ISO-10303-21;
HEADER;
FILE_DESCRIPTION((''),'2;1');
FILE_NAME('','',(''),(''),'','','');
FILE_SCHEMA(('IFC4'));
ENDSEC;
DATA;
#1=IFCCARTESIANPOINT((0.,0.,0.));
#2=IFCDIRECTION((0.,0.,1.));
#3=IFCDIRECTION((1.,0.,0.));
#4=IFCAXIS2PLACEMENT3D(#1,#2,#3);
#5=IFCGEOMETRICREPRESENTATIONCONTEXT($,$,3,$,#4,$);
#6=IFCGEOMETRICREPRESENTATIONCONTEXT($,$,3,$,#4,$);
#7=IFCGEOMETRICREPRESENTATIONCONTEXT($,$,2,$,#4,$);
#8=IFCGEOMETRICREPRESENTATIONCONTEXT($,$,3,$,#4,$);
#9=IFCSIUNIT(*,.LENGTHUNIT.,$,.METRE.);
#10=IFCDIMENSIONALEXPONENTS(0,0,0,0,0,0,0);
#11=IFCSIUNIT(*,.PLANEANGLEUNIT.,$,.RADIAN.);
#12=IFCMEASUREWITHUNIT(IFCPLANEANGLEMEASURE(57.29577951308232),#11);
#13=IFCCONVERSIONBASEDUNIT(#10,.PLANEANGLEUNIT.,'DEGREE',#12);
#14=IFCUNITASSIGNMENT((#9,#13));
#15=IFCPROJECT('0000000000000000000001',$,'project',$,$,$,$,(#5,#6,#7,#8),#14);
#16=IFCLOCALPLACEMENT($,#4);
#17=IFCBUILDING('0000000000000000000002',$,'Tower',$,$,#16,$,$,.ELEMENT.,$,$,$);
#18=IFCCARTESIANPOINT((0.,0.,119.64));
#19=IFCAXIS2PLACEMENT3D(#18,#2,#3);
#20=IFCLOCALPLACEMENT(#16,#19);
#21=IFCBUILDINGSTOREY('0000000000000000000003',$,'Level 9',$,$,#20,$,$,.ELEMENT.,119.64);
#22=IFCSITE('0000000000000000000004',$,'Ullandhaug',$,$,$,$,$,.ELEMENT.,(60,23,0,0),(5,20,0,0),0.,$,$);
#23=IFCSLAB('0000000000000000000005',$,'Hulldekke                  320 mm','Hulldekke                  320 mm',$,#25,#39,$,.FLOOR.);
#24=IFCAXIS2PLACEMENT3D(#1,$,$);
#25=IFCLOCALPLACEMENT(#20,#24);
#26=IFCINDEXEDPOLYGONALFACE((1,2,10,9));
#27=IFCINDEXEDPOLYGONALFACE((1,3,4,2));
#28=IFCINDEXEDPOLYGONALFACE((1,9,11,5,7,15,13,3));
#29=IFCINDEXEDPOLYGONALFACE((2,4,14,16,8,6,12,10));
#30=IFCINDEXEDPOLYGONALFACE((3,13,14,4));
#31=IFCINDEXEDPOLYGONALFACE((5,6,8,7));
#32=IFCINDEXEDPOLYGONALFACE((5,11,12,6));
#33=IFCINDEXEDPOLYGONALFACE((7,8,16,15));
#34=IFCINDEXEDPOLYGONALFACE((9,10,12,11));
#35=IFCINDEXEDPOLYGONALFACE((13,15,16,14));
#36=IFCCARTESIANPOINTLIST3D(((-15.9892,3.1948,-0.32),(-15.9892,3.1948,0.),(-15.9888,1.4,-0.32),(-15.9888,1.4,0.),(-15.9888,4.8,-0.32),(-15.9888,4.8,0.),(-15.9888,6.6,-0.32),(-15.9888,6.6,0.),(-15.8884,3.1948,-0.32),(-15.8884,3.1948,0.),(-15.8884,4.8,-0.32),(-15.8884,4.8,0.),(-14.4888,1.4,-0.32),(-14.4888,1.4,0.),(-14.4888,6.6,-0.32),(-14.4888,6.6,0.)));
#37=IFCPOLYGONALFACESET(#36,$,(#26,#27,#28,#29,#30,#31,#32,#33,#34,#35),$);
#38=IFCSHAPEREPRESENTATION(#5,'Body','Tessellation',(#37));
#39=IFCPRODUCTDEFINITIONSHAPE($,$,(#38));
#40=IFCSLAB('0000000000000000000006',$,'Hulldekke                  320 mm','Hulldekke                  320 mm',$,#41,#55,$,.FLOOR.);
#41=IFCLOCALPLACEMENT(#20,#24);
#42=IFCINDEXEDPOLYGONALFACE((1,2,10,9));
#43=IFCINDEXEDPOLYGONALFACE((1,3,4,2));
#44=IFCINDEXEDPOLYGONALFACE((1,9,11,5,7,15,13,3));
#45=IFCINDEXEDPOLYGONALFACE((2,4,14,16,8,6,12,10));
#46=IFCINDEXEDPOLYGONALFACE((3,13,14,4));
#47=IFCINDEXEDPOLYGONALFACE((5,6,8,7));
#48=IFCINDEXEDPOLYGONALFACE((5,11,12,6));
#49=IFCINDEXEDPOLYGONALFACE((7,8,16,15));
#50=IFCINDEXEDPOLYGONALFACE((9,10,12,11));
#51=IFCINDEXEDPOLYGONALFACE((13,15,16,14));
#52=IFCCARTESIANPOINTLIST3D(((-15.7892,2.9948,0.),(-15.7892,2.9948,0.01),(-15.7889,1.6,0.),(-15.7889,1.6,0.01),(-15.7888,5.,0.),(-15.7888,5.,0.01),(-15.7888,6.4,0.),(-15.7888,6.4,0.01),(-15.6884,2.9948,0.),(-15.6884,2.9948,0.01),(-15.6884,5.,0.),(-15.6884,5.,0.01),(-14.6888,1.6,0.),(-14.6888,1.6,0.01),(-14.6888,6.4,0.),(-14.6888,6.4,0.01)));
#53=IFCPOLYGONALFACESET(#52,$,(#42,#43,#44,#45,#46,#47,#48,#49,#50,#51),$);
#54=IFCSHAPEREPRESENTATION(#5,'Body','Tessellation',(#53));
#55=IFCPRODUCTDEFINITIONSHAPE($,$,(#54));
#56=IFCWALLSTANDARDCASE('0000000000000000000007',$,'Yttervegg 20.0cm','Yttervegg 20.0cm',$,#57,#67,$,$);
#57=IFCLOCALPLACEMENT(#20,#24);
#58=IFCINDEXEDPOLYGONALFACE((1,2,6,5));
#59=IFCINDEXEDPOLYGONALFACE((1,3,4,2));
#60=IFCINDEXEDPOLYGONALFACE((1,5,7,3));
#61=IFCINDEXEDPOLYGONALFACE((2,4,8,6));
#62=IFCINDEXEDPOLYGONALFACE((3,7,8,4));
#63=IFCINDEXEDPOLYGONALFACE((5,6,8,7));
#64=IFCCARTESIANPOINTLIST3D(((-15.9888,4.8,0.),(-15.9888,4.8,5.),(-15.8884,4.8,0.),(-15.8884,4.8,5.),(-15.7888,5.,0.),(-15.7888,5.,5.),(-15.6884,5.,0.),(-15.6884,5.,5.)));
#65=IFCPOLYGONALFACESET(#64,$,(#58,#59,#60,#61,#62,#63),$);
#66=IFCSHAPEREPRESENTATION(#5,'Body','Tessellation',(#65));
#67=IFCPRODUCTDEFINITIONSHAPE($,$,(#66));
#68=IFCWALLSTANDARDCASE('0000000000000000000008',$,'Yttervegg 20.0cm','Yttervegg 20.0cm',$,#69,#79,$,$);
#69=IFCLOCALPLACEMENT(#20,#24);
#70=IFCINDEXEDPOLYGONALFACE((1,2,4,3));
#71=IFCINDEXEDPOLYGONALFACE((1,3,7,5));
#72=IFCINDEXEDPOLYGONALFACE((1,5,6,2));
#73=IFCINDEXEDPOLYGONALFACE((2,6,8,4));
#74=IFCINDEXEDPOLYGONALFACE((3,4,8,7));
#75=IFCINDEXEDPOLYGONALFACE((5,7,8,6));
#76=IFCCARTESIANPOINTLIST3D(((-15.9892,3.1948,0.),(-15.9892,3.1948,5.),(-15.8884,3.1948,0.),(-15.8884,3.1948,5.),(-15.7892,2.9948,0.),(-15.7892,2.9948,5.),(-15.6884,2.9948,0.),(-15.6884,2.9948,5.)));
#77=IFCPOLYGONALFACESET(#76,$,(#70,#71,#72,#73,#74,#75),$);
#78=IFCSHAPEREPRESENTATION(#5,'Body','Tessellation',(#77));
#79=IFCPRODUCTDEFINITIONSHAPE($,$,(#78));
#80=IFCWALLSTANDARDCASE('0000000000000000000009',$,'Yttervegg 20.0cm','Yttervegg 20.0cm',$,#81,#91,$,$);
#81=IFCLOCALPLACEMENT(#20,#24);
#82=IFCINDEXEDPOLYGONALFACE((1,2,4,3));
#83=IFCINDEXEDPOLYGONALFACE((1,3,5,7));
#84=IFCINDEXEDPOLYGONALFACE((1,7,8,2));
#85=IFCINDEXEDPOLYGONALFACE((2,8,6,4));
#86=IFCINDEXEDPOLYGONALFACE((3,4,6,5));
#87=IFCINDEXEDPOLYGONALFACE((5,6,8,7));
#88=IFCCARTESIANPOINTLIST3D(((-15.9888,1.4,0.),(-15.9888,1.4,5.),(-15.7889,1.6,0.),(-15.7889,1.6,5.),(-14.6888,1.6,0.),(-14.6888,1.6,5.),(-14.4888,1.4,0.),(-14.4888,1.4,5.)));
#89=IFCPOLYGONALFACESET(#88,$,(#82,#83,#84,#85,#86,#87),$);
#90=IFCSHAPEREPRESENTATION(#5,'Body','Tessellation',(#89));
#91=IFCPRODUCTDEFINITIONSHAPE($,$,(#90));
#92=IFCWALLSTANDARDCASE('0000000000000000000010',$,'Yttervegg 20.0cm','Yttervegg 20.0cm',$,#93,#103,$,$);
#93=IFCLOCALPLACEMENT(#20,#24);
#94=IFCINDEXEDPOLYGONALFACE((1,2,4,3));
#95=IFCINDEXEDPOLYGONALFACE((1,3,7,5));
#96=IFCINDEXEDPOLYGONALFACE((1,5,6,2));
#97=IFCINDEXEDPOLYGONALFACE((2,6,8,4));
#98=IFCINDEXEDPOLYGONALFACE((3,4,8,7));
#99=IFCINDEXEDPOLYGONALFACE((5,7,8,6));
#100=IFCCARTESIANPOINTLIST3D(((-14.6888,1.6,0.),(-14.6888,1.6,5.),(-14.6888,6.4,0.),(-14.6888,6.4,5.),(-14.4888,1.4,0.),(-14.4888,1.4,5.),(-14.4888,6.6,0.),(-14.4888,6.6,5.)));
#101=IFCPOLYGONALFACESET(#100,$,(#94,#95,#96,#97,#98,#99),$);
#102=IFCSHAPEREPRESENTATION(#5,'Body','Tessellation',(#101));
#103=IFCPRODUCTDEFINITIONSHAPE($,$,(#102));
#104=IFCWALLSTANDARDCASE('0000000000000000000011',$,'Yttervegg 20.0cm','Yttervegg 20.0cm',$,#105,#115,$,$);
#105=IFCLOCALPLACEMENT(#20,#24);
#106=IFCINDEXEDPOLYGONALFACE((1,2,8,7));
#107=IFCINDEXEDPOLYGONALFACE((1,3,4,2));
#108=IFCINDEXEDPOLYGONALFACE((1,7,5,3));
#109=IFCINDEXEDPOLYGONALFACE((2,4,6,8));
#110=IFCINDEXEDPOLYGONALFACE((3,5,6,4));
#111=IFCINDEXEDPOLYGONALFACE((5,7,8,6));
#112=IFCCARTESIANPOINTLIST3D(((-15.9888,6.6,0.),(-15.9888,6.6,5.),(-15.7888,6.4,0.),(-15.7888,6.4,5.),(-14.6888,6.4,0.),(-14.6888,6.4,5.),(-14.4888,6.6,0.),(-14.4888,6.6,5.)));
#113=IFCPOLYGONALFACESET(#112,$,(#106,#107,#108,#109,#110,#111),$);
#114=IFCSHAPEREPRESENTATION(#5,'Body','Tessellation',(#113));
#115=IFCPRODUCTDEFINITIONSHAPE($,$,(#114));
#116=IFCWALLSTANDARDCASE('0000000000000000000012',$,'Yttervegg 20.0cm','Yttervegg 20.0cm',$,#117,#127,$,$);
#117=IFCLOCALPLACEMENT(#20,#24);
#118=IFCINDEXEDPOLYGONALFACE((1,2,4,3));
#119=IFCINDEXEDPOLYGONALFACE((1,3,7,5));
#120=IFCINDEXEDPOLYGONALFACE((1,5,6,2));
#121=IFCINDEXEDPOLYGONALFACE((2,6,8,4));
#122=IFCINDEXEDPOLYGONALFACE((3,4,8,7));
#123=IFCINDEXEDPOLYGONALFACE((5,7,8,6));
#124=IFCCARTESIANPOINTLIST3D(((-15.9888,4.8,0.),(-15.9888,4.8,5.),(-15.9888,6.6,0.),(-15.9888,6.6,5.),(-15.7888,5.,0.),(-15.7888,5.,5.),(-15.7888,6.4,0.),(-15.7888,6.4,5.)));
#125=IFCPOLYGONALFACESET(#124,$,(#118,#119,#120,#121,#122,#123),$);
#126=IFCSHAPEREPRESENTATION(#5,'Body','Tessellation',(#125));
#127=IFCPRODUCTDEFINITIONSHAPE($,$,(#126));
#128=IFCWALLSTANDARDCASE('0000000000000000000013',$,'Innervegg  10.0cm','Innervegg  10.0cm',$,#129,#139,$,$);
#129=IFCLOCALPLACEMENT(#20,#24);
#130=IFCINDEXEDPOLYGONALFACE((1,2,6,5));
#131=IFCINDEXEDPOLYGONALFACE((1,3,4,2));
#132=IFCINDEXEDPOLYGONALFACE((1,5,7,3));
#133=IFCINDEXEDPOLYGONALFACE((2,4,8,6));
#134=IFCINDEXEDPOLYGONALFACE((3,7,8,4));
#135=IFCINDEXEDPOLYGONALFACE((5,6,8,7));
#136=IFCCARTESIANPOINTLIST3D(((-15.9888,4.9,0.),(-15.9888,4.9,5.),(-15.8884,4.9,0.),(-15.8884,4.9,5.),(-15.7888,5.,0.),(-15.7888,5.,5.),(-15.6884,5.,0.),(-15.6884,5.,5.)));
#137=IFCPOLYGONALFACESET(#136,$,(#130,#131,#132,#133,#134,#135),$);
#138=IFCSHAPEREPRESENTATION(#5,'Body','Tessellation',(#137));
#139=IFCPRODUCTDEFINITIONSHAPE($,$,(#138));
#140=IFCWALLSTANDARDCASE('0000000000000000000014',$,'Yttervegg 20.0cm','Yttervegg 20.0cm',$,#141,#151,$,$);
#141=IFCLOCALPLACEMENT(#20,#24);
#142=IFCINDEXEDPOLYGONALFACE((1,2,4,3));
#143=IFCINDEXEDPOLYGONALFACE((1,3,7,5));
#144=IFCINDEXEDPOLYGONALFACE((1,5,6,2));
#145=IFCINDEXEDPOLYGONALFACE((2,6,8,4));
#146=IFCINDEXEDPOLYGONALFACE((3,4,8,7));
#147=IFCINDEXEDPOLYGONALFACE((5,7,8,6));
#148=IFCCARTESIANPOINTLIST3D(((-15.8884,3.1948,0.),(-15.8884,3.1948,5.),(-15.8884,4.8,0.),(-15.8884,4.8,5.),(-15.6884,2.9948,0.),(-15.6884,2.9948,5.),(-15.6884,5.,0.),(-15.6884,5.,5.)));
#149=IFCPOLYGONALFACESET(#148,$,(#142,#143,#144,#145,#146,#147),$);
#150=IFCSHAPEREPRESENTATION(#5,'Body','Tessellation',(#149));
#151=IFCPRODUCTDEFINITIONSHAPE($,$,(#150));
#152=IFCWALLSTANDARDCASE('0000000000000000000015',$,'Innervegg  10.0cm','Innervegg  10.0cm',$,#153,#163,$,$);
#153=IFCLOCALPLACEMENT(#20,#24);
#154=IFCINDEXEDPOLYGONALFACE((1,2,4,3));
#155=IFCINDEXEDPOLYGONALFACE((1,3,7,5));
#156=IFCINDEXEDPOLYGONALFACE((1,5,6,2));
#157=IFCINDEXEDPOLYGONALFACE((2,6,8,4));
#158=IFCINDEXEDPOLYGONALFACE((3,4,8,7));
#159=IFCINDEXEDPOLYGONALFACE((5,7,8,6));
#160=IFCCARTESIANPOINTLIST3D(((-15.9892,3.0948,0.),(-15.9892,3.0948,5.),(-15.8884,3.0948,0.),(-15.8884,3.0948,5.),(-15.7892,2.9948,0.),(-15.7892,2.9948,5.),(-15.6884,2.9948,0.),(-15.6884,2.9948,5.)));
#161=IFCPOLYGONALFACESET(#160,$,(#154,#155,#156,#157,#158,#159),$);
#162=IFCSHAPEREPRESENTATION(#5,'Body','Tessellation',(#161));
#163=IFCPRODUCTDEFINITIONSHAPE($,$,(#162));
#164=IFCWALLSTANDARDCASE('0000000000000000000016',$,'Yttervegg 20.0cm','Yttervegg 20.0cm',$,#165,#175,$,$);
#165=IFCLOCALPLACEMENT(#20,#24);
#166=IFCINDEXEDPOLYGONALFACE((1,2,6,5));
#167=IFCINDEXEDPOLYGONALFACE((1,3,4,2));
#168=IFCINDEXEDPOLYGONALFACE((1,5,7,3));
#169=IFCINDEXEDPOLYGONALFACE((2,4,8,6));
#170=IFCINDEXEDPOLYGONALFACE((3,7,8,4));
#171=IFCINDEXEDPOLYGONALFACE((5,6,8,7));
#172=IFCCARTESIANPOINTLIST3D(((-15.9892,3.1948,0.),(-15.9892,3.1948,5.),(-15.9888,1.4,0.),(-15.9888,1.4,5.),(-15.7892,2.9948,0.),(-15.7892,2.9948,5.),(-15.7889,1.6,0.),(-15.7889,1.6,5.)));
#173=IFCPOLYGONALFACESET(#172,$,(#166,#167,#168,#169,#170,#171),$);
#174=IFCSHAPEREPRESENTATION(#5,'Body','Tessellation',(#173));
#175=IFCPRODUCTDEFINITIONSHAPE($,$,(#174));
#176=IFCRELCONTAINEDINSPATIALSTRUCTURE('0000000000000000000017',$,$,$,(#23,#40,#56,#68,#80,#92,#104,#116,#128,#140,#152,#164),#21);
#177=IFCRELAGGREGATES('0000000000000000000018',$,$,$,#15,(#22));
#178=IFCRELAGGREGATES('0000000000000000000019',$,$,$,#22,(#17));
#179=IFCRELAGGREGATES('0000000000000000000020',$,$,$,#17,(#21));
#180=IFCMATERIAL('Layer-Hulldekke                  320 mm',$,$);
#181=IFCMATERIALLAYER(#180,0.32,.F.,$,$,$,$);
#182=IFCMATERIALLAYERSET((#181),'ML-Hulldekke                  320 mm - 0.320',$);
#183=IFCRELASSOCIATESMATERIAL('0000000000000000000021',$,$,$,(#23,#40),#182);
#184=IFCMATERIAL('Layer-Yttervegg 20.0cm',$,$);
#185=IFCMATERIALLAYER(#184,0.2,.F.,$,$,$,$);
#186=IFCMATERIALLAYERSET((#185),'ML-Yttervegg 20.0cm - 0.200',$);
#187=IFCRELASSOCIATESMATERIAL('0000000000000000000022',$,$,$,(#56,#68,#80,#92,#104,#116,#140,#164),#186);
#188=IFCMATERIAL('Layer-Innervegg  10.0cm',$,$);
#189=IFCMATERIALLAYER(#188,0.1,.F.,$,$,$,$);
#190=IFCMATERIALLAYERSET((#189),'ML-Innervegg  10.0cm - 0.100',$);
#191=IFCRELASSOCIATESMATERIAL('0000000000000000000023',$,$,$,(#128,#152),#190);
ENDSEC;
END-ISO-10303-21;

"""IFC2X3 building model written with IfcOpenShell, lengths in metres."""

from ifc_helpers import new_model, entity, si_unit, converted_unit, frame, origin_with_axes, place, context, project, spatial, polyline, outline, extrude, material, layer, layer_set, layer_usage, element, save


model = new_model("IFC2X3")

# Units and contexts
context_of_model_1 = context(None, 3, world=origin_with_axes())
context_of_model_2 = context(None, 3, world=origin_with_axes())
context_of_model_3 = context(None, 2, world=origin_with_axes())
context_of_model_4 = context(None, 3, world=origin_with_axes())
ifc_project = project(units=[si_unit("LENGTHUNIT", "METRE"), converted_unit("PLANEANGLEUNIT", "DEGREE", entity("IfcPlaneAngleMeasure", 57.29577951308232), si_unit("PLANEANGLEUNIT", "RADIAN"), dimensions=[0, 0, 0, 0, 0, 0, 0])], contexts=[context_of_model_1, context_of_model_2, context_of_model_3, context_of_model_4])

# Site, building, storey
site = spatial("IfcSite", under=ifc_project, Name="Ullandhaug", CompositionType="ELEMENT", RefLatitude=(60, 23, 0, 0), RefLongitude=(5, 20, 0, 0), RefElevation=0.0)
building_placement = place(None, origin_with_axes())
building = spatial("IfcBuilding", under=site, at=building_placement, Name="Tower", CompositionType="ELEMENT")
storey_placement = place(building_placement, frame((0.0, 0.0, 119.64), z_axis=(0.0, 0.0, 1.0), x_axis=(1.0, 0.0, 0.0)))
storey = spatial("IfcBuildingStorey", under=building, at=storey_placement, Name="Level 9", CompositionType="ELEMENT", Elevation=119.64)

# Slabs
ifc_material_1 = material(Name="Layer-Hulldekke                  320 mm")
ifc_layer_1 = layer(ifc_material_1, 0.32, ventilated=False)
ifc_layer_set_1 = layer_set([ifc_layer_1], Name="ML-Hulldekke                  320 mm - 0.320")
ifc_layer_usage_1 = layer_usage(ifc_layer_set_1, "AXIS2", "POSITIVE", 0.0)
slab_1_placement = place(storey_placement, frame((-15.9888, 1.4, 0.0), z_axis=(0.0, 0.0, 1.0), x_axis=(1.0, 0.0, 0.0)))
element("IfcSlab", 1, at=slab_1_placement, inside=storey, material=ifc_layer_usage_1, Name="Hulldekke                  320 mm", Description="Hulldekke                  320 mm", PredefinedType="FLOOR", context=context_of_model_1, shape_type="SweptSolid", body=[
    extrude(outline(polyline([(0.0, 0.0), (1.5, 0.0), (1.5, 5.2), (0.0, 5.2), (0.0, 3.4), (0.1005, 3.4), (0.1005, 1.7948), (-0.0004, 1.7948), (0.0, 0.0)])), origin_with_axes(), (0.0, 0.0, -1.0), 0.32),
])
slab_2_placement = place(storey_placement, frame((-15.7889, 1.6, 0.0), z_axis=(0.0, 0.0, 1.0), x_axis=(1.0, 0.0, 0.0)))
element("IfcSlab", 2, at=slab_2_placement, inside=storey, material=ifc_layer_usage_1, Name="Hulldekke                  320 mm", Description="Hulldekke                  320 mm", PredefinedType="FLOOR", context=context_of_model_1, shape_type="SweptSolid", body=[
    extrude(outline(polyline([(0.0, 0.0), (1.1, 0.0), (1.1, 4.8), (0.0, 4.8), (0.0, 3.4), (0.1005, 3.4), (0.1005, 1.3948), (-0.0003, 1.3948), (0.0, 0.0)])), origin_with_axes(), (0.0, 0.0, 1.0), 0.01),
])

# Walls
ifc_material_2 = material(Name="Layer-Yttervegg 20.0cm")
ifc_layer_2 = layer(ifc_material_2, 0.2, ventilated=False)
ifc_layer_set_2 = layer_set([ifc_layer_2], Name="ML-Yttervegg 20.0cm - 0.200")
ifc_layer_usage_2 = layer_usage(ifc_layer_set_2, "AXIS2", "POSITIVE", 0.0)
wall_1_placement = place(storey_placement, frame((-15.9888, 4.8, 0.0), z_axis=(0.0, 0.0, 1.0), x_axis=(1.0, 0.0, 0.0)))
element("IfcWallStandardCase", 3, at=wall_1_placement, inside=storey, material=ifc_layer_usage_2, Name="Yttervegg 20.0cm", Description="Yttervegg 20.0cm", context=context_of_model_1, shape_type="SweptSolid", body=[
    extrude(outline(polyline([(0.0, 0.0), (0.1005, 0.0), (0.3005, 0.2), (0.2, 0.2), (0.0, 0.0)])), origin_with_axes(), (0.0, 0.0, 1.0), 5.0),
])
wall_2_placement = place(storey_placement, frame((-15.8884, 3.1948, 0.0), z_axis=(0.0, 0.0, 1.0), x_axis=(-1.0, 0.0, 0.0)))
element("IfcWallStandardCase", 4, at=wall_2_placement, inside=storey, material=ifc_layer_usage_2, Name="Yttervegg 20.0cm", Description="Yttervegg 20.0cm", context=context_of_model_1, shape_type="SweptSolid", body=[
    extrude(outline(polyline([(0.0, 0.0), (0.1009, 0.0), (-0.0992, 0.2), (-0.2, 0.2), (0.0, 0.0)])), frame((0.0, 0.0, 0.0), z_axis=(0.0, 0.0, 1.0), x_axis=(1.0, 0.0, 0.0)), (0.0, 0.0, 1.0), 5.0),
])
wall_3_placement = place(storey_placement, frame((-15.9888, 1.4, 0.0), z_axis=(0.0, 0.0, 1.0), x_axis=(1.0, 0.0, 0.0)))
element("IfcWallStandardCase", 5, at=wall_3_placement, inside=storey, material=ifc_layer_usage_2, Name="Yttervegg 20.0cm", Description="Yttervegg 20.0cm", context=context_of_model_1, shape_type="SweptSolid", body=[
    extrude(outline(polyline([(0.0, 0.0), (1.5, 0.0), (1.3, 0.2), (0.2, 0.2), (0.0, 0.0)])), origin_with_axes(), (0.0, 0.0, 1.0), 5.0),
])
wall_4_placement = place(storey_placement, frame((-14.4888, 1.4, 0.0), z_axis=(0.0, 0.0, 1.0), x_axis=(0.0, 1.0, 0.0)))
element("IfcWallStandardCase", 6, at=wall_4_placement, inside=storey, material=ifc_layer_usage_2, Name="Yttervegg 20.0cm", Description="Yttervegg 20.0cm", context=context_of_model_1, shape_type="SweptSolid", body=[
    extrude(outline(polyline([(0.0, 0.0), (5.2, 0.0), (5.0, 0.2), (0.2, 0.2), (0.0, 0.0)])), frame((0.0, 0.0, 0.0), z_axis=(0.0, 0.0, 1.0), x_axis=(1.0, 0.0, 0.0)), (0.0, 0.0, 1.0), 5.0),
])
wall_5_placement = place(storey_placement, frame((-14.4888, 6.6, 0.0), z_axis=(0.0, 0.0, 1.0), x_axis=(-1.0, 0.0, 0.0)))
element("IfcWallStandardCase", 7, at=wall_5_placement, inside=storey, material=ifc_layer_usage_2, Name="Yttervegg 20.0cm", Description="Yttervegg 20.0cm", context=context_of_model_1, shape_type="SweptSolid", body=[
    extrude(outline(polyline([(0.0, 0.0), (1.5, 0.0), (1.3, 0.2), (0.2, 0.2), (0.0, 0.0)])), frame((0.0, 0.0, 0.0), z_axis=(0.0, 0.0, 1.0), x_axis=(1.0, 0.0, 0.0)), (0.0, 0.0, 1.0), 5.0),
])
wall_6_placement = place(storey_placement, frame((-15.9888, 6.6, 0.0), z_axis=(0.0, 0.0, 1.0), x_axis=(0.0, -1.0, 0.0)))
element("IfcWallStandardCase", 8, at=wall_6_placement, inside=storey, material=ifc_layer_usage_2, Name="Yttervegg 20.0cm", Description="Yttervegg 20.0cm", context=context_of_model_1, shape_type="SweptSolid", body=[
    extrude(outline(polyline([(0.0, 0.0), (1.8, 0.0), (1.6, 0.2), (0.2, 0.2), (0.0, 0.0)])), frame((0.0, 0.0, 0.0), z_axis=(0.0, 0.0, 1.0), x_axis=(1.0, 0.0, 0.0)), (0.0, 0.0, 1.0), 5.0),
])
ifc_material_3 = material(Name="Layer-Innervegg  10.0cm")
ifc_layer_3 = layer(ifc_material_3, 0.1, ventilated=False)
ifc_layer_set_3 = layer_set([ifc_layer_3], Name="ML-Innervegg  10.0cm - 0.100")
ifc_layer_usage_3 = layer_usage(ifc_layer_set_3, "AXIS2", "POSITIVE", 0.0)
wall_7_placement = place(storey_placement, frame((-15.9888, 4.9, 0.0), z_axis=(0.0, 0.0, 1.0), x_axis=(1.0, 0.0, 0.0)))
element("IfcWallStandardCase", 9, at=wall_7_placement, inside=storey, material=ifc_layer_usage_3, Name="Innervegg  10.0cm", Description="Innervegg  10.0cm", context=context_of_model_1, shape_type="SweptSolid", body=[
    extrude(outline(polyline([(0.0, 0.0), (0.1005, 0.0), (0.3005, 0.1), (0.2, 0.1), (0.0, 0.0)])), origin_with_axes(), (0.0, 0.0, 1.0), 5.0),
])
wall_8_placement = place(storey_placement, frame((-15.8884, 4.8, 0.0), z_axis=(0.0, 0.0, 1.0), x_axis=(0.0, -1.0, 0.0)))
element("IfcWallStandardCase", 10, at=wall_8_placement, inside=storey, material=ifc_layer_usage_2, Name="Yttervegg 20.0cm", Description="Yttervegg 20.0cm", context=context_of_model_1, shape_type="SweptSolid", body=[
    extrude(outline(polyline([(0.0, 0.0), (1.6052, 0.0), (1.8052, 0.2), (-0.2, 0.2), (0.0, 0.0)])), frame((0.0, 0.0, 0.0), z_axis=(0.0, 0.0, 1.0), x_axis=(1.0, 0.0, 0.0)), (0.0, 0.0, 1.0), 5.0),
])
wall_9_placement = place(storey_placement, frame((-15.8884, 3.0948, 0.0), z_axis=(0.0, 0.0, 1.0), x_axis=(-1.0, 0.0, 0.0)))
element("IfcWallStandardCase", 11, at=wall_9_placement, inside=storey, material=ifc_layer_usage_3, Name="Innervegg  10.0cm", Description="Innervegg  10.0cm", context=context_of_model_1, shape_type="SweptSolid", body=[
    extrude(outline(polyline([(0.0, 0.0), (0.1009, 0.0), (-0.0992, 0.1), (-0.2, 0.1), (0.0, 0.0)])), frame((0.0, 0.0, 0.0), z_axis=(0.0, 0.0, 1.0), x_axis=(1.0, 0.0, 0.0)), (0.0, 0.0, 1.0), 5.0),
])
wall_10_placement = place(storey_placement, frame((-15.9892, 3.1948, 0.0), z_axis=(0.0, 0.0, 1.0), x_axis=(0.000225, -1.0, 0.0)))
element("IfcWallStandardCase", 12, at=wall_10_placement, inside=storey, material=ifc_layer_usage_2, Name="Yttervegg 20.0cm", Description="Yttervegg 20.0cm", context=context_of_model_1, shape_type="SweptSolid", body=[
    extrude(outline(polyline([(0.0, 0.0), (1.7948, 0.0), (1.5948, 0.2), (0.2, 0.2), (0.0, 0.0)])), frame((0.0, 0.0, 0.0), z_axis=(0.0, 0.0, 1.0), x_axis=(1.0, 0.0, 0.0)), (0.0, 0.0, 1.0), 5.0),
])

save(model, "model.ifc")
